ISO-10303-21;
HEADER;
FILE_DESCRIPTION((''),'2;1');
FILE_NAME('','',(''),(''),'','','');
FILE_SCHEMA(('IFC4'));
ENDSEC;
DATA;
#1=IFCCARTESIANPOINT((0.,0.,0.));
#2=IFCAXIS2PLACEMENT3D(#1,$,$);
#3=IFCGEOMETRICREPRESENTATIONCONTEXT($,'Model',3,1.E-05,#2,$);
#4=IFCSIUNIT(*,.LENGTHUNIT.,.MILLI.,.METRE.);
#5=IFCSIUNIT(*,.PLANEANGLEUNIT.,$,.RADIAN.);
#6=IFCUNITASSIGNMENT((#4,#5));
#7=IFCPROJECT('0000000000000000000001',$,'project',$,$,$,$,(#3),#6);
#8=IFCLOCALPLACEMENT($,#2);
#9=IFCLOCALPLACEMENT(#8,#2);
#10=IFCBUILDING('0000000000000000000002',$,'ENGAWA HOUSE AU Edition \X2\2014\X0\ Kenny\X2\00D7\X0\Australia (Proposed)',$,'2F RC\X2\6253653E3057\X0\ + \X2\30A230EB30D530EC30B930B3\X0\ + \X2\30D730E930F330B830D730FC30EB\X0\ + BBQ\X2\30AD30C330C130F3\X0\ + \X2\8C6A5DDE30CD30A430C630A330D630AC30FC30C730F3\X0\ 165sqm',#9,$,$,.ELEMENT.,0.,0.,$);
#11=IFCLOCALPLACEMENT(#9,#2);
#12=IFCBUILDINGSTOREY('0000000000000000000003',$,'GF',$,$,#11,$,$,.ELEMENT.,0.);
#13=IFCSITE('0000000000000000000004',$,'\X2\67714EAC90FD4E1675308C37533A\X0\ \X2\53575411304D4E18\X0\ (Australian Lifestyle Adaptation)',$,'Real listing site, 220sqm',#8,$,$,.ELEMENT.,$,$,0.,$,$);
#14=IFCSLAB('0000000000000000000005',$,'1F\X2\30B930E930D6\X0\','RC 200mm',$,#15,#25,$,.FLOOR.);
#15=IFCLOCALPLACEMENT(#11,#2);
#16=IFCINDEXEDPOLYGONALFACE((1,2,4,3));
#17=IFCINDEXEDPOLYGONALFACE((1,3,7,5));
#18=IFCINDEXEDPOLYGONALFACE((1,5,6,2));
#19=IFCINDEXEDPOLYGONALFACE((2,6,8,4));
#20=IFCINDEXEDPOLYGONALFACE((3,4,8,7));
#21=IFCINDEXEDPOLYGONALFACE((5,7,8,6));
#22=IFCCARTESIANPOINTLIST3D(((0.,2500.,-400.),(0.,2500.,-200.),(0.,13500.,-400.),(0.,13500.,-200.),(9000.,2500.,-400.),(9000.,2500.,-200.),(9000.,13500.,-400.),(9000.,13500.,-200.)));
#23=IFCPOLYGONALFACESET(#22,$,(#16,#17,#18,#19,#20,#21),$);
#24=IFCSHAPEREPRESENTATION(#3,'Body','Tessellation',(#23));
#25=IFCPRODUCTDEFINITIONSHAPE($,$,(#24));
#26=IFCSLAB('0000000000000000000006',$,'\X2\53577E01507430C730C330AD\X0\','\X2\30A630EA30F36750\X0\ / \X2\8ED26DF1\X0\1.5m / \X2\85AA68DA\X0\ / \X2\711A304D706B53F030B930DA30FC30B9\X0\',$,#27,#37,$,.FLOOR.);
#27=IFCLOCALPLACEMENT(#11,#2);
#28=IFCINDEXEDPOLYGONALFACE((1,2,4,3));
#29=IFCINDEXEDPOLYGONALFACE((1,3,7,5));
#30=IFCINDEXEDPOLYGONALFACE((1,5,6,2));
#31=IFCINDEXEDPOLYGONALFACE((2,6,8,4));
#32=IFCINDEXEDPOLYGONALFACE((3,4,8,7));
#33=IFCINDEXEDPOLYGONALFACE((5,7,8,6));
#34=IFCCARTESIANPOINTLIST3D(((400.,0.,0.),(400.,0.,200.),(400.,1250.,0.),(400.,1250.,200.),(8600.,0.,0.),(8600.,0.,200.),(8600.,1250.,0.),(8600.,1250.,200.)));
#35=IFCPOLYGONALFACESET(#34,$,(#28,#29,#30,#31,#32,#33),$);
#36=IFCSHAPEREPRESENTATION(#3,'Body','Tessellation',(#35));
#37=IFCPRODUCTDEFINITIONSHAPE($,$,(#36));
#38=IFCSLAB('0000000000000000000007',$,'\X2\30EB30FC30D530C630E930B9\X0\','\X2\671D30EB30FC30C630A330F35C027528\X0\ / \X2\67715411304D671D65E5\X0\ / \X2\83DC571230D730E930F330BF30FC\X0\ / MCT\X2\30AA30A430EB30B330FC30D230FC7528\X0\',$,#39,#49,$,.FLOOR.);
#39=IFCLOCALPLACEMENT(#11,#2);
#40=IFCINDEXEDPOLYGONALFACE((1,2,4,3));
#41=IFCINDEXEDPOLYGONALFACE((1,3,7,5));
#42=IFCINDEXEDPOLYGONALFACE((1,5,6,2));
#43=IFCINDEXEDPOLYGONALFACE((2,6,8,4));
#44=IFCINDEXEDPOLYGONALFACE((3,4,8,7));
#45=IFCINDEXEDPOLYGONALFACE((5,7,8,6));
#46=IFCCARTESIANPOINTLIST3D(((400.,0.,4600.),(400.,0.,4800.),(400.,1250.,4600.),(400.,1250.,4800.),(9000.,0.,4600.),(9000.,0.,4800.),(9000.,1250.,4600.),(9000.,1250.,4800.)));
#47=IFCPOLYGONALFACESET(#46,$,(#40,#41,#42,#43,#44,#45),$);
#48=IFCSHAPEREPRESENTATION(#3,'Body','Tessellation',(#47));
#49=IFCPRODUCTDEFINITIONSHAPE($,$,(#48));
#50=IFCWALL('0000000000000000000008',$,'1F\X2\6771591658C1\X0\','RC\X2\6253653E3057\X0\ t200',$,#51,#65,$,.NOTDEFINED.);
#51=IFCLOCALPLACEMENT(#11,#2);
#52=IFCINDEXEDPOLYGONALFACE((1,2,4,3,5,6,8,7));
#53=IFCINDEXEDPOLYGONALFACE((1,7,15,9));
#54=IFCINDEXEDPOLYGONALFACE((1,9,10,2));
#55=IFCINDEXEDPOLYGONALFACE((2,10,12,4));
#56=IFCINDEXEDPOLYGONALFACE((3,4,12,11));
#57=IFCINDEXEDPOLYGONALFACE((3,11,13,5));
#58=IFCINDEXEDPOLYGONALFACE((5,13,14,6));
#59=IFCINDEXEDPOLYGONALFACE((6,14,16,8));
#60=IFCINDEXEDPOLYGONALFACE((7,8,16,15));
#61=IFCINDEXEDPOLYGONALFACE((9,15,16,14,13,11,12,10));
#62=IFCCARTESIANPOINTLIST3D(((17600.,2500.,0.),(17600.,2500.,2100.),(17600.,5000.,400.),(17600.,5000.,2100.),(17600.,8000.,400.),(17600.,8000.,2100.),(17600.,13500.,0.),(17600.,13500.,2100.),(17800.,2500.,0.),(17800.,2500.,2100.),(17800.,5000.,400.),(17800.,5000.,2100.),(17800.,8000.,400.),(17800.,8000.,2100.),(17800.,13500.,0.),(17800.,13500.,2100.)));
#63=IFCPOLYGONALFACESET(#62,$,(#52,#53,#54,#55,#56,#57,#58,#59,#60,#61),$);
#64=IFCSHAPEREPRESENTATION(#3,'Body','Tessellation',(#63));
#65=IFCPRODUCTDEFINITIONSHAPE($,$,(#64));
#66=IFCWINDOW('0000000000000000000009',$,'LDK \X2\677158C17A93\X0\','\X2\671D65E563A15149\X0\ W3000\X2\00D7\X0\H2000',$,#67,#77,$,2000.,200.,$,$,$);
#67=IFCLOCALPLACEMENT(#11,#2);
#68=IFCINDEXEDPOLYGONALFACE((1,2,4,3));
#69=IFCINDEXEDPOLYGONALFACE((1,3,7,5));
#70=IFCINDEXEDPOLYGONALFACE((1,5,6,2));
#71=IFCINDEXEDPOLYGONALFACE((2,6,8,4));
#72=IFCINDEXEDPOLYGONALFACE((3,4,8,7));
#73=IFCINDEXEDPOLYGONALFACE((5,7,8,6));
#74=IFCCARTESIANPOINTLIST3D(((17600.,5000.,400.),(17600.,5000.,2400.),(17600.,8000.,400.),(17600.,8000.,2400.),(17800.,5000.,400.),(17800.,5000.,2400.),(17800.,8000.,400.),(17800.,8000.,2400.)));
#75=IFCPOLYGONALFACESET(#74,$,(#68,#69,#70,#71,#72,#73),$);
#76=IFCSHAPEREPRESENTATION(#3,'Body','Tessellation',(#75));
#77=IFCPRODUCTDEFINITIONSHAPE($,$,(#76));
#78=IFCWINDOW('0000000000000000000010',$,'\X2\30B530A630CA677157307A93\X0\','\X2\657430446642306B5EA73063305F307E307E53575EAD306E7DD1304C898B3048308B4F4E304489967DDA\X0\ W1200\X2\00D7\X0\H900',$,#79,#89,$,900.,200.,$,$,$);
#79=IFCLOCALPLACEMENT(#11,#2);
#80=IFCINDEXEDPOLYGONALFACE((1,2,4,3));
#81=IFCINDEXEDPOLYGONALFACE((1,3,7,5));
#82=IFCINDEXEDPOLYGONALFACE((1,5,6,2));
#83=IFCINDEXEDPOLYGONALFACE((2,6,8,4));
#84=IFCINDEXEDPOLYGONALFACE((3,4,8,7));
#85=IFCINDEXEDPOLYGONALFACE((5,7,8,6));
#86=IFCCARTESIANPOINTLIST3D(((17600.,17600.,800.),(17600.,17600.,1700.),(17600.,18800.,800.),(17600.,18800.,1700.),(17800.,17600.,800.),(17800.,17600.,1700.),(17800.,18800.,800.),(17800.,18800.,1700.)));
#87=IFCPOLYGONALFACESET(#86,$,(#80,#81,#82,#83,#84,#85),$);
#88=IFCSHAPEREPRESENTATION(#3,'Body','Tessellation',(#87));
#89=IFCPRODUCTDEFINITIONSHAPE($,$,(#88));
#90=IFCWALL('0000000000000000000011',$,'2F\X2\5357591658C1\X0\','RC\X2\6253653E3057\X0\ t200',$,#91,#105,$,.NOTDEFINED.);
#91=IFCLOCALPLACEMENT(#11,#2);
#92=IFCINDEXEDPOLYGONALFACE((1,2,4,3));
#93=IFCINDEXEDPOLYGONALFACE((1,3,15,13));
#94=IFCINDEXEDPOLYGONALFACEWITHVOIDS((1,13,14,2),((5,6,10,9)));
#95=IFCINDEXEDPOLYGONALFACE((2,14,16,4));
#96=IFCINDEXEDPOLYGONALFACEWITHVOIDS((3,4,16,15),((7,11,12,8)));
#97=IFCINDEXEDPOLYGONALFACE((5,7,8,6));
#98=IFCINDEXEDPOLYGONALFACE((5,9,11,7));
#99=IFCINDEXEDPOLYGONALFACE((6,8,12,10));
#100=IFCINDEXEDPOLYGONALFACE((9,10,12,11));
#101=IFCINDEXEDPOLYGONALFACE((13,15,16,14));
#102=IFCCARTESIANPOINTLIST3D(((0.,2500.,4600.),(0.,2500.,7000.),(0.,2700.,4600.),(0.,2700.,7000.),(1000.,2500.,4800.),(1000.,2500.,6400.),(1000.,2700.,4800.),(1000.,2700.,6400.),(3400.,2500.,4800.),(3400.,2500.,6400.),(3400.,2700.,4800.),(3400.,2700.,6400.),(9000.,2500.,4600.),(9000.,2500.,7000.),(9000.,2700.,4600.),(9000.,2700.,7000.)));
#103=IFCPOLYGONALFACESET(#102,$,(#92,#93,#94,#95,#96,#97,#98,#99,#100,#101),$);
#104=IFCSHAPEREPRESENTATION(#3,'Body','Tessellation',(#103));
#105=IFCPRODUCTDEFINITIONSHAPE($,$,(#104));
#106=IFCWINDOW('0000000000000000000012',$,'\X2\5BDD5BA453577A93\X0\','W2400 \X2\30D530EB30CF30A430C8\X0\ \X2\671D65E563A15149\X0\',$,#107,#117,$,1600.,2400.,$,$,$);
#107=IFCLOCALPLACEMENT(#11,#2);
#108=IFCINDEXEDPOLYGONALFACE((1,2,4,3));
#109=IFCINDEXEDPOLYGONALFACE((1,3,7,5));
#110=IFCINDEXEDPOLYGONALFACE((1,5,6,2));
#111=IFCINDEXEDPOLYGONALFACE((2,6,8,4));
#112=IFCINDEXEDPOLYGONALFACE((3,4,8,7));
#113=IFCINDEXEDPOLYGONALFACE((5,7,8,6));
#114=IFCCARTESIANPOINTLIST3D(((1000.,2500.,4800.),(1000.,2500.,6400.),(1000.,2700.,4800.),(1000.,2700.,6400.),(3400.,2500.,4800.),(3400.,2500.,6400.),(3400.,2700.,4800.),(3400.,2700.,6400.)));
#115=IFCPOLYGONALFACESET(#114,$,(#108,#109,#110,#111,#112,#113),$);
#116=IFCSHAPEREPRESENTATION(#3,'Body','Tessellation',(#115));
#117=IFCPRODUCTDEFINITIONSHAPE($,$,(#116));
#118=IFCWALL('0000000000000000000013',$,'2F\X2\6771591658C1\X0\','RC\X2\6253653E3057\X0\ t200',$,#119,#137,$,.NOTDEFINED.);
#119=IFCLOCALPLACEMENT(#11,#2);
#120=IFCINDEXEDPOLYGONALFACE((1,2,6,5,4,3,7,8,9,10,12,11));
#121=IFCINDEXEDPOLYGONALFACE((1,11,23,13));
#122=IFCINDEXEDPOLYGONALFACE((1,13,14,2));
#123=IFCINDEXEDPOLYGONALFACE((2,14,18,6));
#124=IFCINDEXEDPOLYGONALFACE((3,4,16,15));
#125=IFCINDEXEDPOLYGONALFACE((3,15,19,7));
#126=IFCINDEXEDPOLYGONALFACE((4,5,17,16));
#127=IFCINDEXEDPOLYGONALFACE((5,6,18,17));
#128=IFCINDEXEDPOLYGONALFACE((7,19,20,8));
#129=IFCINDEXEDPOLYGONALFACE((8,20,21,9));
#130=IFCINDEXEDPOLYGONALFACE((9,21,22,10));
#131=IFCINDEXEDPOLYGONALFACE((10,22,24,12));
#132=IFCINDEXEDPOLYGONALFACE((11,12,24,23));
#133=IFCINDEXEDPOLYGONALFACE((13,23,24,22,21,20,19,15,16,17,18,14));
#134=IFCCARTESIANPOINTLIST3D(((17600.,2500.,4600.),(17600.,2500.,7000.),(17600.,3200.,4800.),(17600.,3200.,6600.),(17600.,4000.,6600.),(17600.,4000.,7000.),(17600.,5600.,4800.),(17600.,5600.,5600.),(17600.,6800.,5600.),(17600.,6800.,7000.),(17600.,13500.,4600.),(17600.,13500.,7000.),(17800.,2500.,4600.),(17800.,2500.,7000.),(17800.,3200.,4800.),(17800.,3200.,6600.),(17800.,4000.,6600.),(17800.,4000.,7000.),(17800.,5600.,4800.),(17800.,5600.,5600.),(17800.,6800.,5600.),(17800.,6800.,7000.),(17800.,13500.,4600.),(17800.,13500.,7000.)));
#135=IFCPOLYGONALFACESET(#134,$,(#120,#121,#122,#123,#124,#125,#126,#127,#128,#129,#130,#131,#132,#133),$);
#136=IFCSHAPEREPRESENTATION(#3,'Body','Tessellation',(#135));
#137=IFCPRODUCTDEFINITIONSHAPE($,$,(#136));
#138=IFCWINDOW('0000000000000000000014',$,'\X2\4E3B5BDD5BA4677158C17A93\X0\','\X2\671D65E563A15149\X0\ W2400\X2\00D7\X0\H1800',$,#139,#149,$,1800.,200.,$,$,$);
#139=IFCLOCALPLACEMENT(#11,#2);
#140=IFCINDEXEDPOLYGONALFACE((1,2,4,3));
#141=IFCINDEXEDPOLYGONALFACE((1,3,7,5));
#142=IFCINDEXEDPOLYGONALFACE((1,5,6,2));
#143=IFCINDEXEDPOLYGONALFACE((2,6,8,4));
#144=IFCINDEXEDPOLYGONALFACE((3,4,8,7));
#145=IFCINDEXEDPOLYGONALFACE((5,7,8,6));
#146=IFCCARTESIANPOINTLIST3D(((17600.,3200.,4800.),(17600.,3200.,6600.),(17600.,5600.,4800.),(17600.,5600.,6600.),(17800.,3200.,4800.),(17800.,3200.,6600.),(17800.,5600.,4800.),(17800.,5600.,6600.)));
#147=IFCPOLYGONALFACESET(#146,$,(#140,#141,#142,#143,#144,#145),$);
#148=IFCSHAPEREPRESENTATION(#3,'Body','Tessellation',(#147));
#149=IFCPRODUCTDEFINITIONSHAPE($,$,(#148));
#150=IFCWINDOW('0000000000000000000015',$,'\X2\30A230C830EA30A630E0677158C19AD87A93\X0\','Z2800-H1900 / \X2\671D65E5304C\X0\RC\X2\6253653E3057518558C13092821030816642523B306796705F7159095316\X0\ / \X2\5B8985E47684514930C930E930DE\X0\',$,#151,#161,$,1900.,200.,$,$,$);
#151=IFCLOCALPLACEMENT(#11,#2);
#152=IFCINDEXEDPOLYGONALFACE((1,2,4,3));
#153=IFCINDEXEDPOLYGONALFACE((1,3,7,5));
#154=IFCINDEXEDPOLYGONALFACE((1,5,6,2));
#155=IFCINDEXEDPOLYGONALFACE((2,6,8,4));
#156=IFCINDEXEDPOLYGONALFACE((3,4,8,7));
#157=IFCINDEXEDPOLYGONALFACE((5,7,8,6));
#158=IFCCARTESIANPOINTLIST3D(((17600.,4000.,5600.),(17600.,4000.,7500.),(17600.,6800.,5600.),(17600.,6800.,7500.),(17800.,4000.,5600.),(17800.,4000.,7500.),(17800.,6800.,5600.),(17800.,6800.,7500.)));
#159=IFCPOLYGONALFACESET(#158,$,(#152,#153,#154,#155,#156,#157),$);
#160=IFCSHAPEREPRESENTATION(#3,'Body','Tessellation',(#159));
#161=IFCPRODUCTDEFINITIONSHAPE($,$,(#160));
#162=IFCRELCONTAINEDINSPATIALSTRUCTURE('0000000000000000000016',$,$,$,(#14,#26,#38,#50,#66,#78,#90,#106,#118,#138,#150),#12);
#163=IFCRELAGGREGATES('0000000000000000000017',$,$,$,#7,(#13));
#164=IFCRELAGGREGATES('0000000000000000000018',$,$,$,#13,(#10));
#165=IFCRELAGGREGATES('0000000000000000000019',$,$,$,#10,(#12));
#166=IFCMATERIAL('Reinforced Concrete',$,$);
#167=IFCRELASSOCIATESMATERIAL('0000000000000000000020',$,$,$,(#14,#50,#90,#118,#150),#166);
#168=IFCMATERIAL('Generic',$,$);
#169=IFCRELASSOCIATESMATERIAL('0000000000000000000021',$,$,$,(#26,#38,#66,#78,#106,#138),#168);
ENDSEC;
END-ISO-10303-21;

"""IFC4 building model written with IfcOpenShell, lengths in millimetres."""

from ifc_helpers import new_model, si_unit, frame, frame_2d, origin, place, context, project, spatial, rectangle, extrude, material, element, fill, save


model = new_model("IFC4")

# Units and contexts
model_context = context("Model", 3, precision=1e-05, world=origin())
ifc_project = project(units=[si_unit("LENGTHUNIT", "METRE", prefix="MILLI"), si_unit("PLANEANGLEUNIT", "RADIAN")], contexts=[model_context])

# Site, building, storey
site_placement = place(None, origin())
site = spatial("IfcSite", under=ifc_project, at=site_placement, Name="東京都世田谷区 南向き丘 (Australian Lifestyle Adaptation)", ObjectType="Real listing site, 220sqm", CompositionType="ELEMENT", RefElevation=0.0)
building_placement = place(site_placement, origin())
building = spatial("IfcBuilding", under=site, at=building_placement, Name="ENGAWA HOUSE AU Edition — Kenny×Australia (Proposed)", ObjectType="2F RC打放し + アルフレスコ + プランジプール + BBQキッチン + 豪州ネイティブガーデン 165sqm", CompositionType="ELEMENT", ElevationOfRefHeight=0.0, ElevationOfTerrain=0.0)
storey_placement = place(building_placement, origin())
storey = spatial("IfcBuildingStorey", under=building, at=storey_placement, Name="GF", CompositionType="ELEMENT", Elevation=0.0)

# Shared definitions
ifc_material_1 = material(Name="Generic")

# Slabs
ifc_material_2 = material(Name="Reinforced Concrete")
slab_1_placement = place(storey_placement, frame((0.0, 1250.0, -200.0)))
element("IfcSlab", 1, at=slab_1_placement, inside=storey, material=ifc_material_2, Name="1Fスラブ", Description="RC 200mm", PredefinedType="FLOOR", context=model_context, shape_type="SweptSolid", body=[
    extrude(rectangle(XDim=9000.0, YDim=11000.0, at=frame_2d((4500.0, 5500.0))), frame((0.0, 1250.0, -200.0)), (0.0, 0.0, 1.0), 200.0),
])
slab_2_placement = place(storey_placement, frame((200.0, 0.0, 0.0)))
element("IfcSlab", 2, at=slab_2_placement, inside=storey, material=ifc_material_1, Name="南縁側デッキ", Description="ウリン材 / 軒深1.5m / 薪棚 / 焚き火台スペース", PredefinedType="FLOOR", context=model_context, shape_type="SweptSolid", body=[
    extrude(rectangle(XDim=8200.0, YDim=1250.0, at=frame_2d((4100.0, 625.0))), frame((200.0, 0.0, 0.0)), (0.0, 0.0, 1.0), 200.0),
])
slab_3_placement = place(storey_placement, frame((200.0, 0.0, 2300.0)))
element("IfcSlab", 3, at=slab_3_placement, inside=storey, material=ifc_material_1, Name="ルーフテラス", Description="朝ルーティン専用 / 東向き朝日 / 菜園プランター / MCTオイルコーヒー用", PredefinedType="FLOOR", context=model_context, shape_type="SweptSolid", body=[
    extrude(rectangle(XDim=8600.0, YDim=1250.0, at=frame_2d((4300.0, 625.0))), frame((200.0, 0.0, 2300.0)), (0.0, 0.0, 1.0), 200.0),
])

# Wall, openings, windows
wall_1_placement = place(storey_placement, frame((8800.0, 1250.0, 0.0)))
wall_1 = element("IfcWall", 4, at=wall_1_placement, inside=storey, material=ifc_material_2, Name="1F東外壁", Description="RC打放し t200", PredefinedType="NOTDEFINED", context=model_context, shape_type="SweptSolid", body=[
    extrude(rectangle(XDim=200.0, YDim=11000.0, at=frame_2d((100.0, 5500.0))), frame((8800.0, 1250.0, 0.0)), (0.0, 0.0, 1.0), 2100.0),
])
opening_1_placement = place(storey_placement, frame((8800.0, 2500.0, 200.0)))
opening_1 = element("IfcOpeningElement", 5, at=opening_1_placement, cuts=wall_1, PredefinedType="NOTDEFINED", context=model_context, shape_type="SweptSolid", body=[
    extrude(rectangle(XDim=200.0, YDim=3000.0, at=frame_2d((100.0, 1500.0))), frame((8800.0, 2500.0, 200.0)), (0.0, 0.0, 1.0), 2000.0),
])
opening_2_placement = place(storey_placement, frame((8800.0, 8800.0, 400.0)))
opening_2 = element("IfcOpeningElement", 6, at=opening_2_placement, cuts=wall_1, PredefinedType="NOTDEFINED", context=model_context, shape_type="SweptSolid", body=[
    extrude(rectangle(XDim=200.0, YDim=1200.0, at=frame_2d((100.0, 600.0))), frame((8800.0, 8800.0, 400.0)), (0.0, 0.0, 1.0), 900.0),
])
window_1_placement = place(storey_placement, frame((8800.0, 2500.0, 200.0)))
window_1 = element("IfcWindow", 7, at=window_1_placement, inside=storey, material=ifc_material_1, Name="LDK 東壁窓", Description="朝日採光 W3000×H2000", OverallHeight=2000.0, OverallWidth=200.0, context=model_context, shape_type="SweptSolid", body=[
    extrude(rectangle(XDim=200.0, YDim=3000.0, at=frame_2d((100.0, 1500.0))), frame((8800.0, 2500.0, 200.0)), (0.0, 0.0, 1.0), 2000.0),
])
fill(opening_1, window_1)
window_2_placement = place(storey_placement, frame((8800.0, 8800.0, 400.0)))
window_2 = element("IfcWindow", 8, at=window_2_placement, inside=storey, material=ifc_material_1, Name="サウナ東地窓", Description="整い時に座ったまま南庭の緑が見える低い視線 W1200×H900", OverallHeight=900.0, OverallWidth=200.0, context=model_context, shape_type="SweptSolid", body=[
    extrude(rectangle(XDim=200.0, YDim=1200.0, at=frame_2d((100.0, 600.0))), frame((8800.0, 8800.0, 400.0)), (0.0, 0.0, 1.0), 900.0),
])
fill(opening_2, window_2)

# Wall, opening, window
wall_2_placement = place(storey_placement, frame((0.0, 1250.0, 2300.0)))
wall_2 = element("IfcWall", 9, at=wall_2_placement, inside=storey, material=ifc_material_2, Name="2F南外壁", Description="RC打放し t200", PredefinedType="NOTDEFINED", context=model_context, shape_type="SweptSolid", body=[
    extrude(rectangle(XDim=9000.0, YDim=200.0, at=frame_2d((4500.0, 100.0))), frame((0.0, 1250.0, 2300.0)), (0.0, 0.0, 1.0), 2400.0),
])
opening_3_placement = place(storey_placement, frame((500.0, 1250.0, 2400.0)))
opening_3 = element("IfcOpeningElement", 10, at=opening_3_placement, cuts=wall_2, PredefinedType="NOTDEFINED", context=model_context, shape_type="SweptSolid", body=[
    extrude(rectangle(XDim=2400.0, YDim=200.0, at=frame_2d((1200.0, 100.0))), frame((500.0, 1250.0, 2400.0)), (0.0, 0.0, 1.0), 1600.0),
])
window_3_placement = place(storey_placement, frame((500.0, 1250.0, 2400.0)))
window_3 = element("IfcWindow", 11, at=window_3_placement, inside=storey, material=ifc_material_1, Name="寝室南窓", Description="W2400 フルハイト 朝日採光", OverallHeight=1600.0, OverallWidth=2400.0, context=model_context, shape_type="SweptSolid", body=[
    extrude(rectangle(XDim=2400.0, YDim=200.0, at=frame_2d((1200.0, 100.0))), frame((500.0, 1250.0, 2400.0)), (0.0, 0.0, 1.0), 1600.0),
])
fill(opening_3, window_3)

# Wall, openings, windows
wall_3_placement = place(storey_placement, frame((8800.0, 1250.0, 2300.0)))
wall_3 = element("IfcWall", 12, at=wall_3_placement, inside=storey, material=ifc_material_2, Name="2F東外壁", Description="RC打放し t200", PredefinedType="NOTDEFINED", context=model_context, shape_type="SweptSolid", body=[
    extrude(rectangle(XDim=200.0, YDim=11000.0, at=frame_2d((100.0, 5500.0))), frame((8800.0, 1250.0, 2300.0)), (0.0, 0.0, 1.0), 2400.0),
])
opening_4_placement = place(storey_placement, frame((8800.0, 1600.0, 2400.0)))
opening_4 = element("IfcOpeningElement", 13, at=opening_4_placement, cuts=wall_3, PredefinedType="NOTDEFINED", context=model_context, shape_type="SweptSolid", body=[
    extrude(rectangle(XDim=200.0, YDim=2400.0, at=frame_2d((100.0, 1200.0))), frame((8800.0, 1600.0, 2400.0)), (0.0, 0.0, 1.0), 1800.0),
])
opening_5_placement = place(storey_placement, frame((8800.0, 2000.0, 2800.0)))
opening_5 = element("IfcOpeningElement", 14, at=opening_5_placement, cuts=wall_3, PredefinedType="NOTDEFINED", context=model_context, shape_type="SweptSolid", body=[
    extrude(rectangle(XDim=200.0, YDim=2800.0, at=frame_2d((100.0, 1400.0))), frame((8800.0, 2000.0, 2800.0)), (0.0, 0.0, 1.0), 1900.0),
])
window_4_placement = place(storey_placement, frame((8800.0, 1600.0, 2400.0)))
window_4 = element("IfcWindow", 15, at=window_4_placement, inside=storey, material=ifc_material_1, Name="主寝室東壁窓", Description="朝日採光 W2400×H1800", OverallHeight=1800.0, OverallWidth=200.0, context=model_context, shape_type="SweptSolid", body=[
    extrude(rectangle(XDim=200.0, YDim=2400.0, at=frame_2d((100.0, 1200.0))), frame((8800.0, 1600.0, 2400.0)), (0.0, 0.0, 1.0), 1800.0),
])
fill(opening_4, window_4)
window_5_placement = place(storey_placement, frame((8800.0, 2000.0, 2800.0)))
window_5 = element("IfcWindow", 16, at=window_5_placement, inside=storey, material=ifc_material_2, Name="アトリウム東壁高窓", Description="Z2800-H1900 / 朝日がRC打放し内壁を舐め時刻で陰影変化 / 安藤的光ドラマ", OverallHeight=1900.0, OverallWidth=200.0, context=model_context, shape_type="SweptSolid", body=[
    extrude(rectangle(XDim=200.0, YDim=2800.0, at=frame_2d((100.0, 1400.0))), frame((8800.0, 2000.0, 2800.0)), (0.0, 0.0, 1.0), 1900.0),
])
fill(opening_5, window_5)

save(model, "model.ifc")
